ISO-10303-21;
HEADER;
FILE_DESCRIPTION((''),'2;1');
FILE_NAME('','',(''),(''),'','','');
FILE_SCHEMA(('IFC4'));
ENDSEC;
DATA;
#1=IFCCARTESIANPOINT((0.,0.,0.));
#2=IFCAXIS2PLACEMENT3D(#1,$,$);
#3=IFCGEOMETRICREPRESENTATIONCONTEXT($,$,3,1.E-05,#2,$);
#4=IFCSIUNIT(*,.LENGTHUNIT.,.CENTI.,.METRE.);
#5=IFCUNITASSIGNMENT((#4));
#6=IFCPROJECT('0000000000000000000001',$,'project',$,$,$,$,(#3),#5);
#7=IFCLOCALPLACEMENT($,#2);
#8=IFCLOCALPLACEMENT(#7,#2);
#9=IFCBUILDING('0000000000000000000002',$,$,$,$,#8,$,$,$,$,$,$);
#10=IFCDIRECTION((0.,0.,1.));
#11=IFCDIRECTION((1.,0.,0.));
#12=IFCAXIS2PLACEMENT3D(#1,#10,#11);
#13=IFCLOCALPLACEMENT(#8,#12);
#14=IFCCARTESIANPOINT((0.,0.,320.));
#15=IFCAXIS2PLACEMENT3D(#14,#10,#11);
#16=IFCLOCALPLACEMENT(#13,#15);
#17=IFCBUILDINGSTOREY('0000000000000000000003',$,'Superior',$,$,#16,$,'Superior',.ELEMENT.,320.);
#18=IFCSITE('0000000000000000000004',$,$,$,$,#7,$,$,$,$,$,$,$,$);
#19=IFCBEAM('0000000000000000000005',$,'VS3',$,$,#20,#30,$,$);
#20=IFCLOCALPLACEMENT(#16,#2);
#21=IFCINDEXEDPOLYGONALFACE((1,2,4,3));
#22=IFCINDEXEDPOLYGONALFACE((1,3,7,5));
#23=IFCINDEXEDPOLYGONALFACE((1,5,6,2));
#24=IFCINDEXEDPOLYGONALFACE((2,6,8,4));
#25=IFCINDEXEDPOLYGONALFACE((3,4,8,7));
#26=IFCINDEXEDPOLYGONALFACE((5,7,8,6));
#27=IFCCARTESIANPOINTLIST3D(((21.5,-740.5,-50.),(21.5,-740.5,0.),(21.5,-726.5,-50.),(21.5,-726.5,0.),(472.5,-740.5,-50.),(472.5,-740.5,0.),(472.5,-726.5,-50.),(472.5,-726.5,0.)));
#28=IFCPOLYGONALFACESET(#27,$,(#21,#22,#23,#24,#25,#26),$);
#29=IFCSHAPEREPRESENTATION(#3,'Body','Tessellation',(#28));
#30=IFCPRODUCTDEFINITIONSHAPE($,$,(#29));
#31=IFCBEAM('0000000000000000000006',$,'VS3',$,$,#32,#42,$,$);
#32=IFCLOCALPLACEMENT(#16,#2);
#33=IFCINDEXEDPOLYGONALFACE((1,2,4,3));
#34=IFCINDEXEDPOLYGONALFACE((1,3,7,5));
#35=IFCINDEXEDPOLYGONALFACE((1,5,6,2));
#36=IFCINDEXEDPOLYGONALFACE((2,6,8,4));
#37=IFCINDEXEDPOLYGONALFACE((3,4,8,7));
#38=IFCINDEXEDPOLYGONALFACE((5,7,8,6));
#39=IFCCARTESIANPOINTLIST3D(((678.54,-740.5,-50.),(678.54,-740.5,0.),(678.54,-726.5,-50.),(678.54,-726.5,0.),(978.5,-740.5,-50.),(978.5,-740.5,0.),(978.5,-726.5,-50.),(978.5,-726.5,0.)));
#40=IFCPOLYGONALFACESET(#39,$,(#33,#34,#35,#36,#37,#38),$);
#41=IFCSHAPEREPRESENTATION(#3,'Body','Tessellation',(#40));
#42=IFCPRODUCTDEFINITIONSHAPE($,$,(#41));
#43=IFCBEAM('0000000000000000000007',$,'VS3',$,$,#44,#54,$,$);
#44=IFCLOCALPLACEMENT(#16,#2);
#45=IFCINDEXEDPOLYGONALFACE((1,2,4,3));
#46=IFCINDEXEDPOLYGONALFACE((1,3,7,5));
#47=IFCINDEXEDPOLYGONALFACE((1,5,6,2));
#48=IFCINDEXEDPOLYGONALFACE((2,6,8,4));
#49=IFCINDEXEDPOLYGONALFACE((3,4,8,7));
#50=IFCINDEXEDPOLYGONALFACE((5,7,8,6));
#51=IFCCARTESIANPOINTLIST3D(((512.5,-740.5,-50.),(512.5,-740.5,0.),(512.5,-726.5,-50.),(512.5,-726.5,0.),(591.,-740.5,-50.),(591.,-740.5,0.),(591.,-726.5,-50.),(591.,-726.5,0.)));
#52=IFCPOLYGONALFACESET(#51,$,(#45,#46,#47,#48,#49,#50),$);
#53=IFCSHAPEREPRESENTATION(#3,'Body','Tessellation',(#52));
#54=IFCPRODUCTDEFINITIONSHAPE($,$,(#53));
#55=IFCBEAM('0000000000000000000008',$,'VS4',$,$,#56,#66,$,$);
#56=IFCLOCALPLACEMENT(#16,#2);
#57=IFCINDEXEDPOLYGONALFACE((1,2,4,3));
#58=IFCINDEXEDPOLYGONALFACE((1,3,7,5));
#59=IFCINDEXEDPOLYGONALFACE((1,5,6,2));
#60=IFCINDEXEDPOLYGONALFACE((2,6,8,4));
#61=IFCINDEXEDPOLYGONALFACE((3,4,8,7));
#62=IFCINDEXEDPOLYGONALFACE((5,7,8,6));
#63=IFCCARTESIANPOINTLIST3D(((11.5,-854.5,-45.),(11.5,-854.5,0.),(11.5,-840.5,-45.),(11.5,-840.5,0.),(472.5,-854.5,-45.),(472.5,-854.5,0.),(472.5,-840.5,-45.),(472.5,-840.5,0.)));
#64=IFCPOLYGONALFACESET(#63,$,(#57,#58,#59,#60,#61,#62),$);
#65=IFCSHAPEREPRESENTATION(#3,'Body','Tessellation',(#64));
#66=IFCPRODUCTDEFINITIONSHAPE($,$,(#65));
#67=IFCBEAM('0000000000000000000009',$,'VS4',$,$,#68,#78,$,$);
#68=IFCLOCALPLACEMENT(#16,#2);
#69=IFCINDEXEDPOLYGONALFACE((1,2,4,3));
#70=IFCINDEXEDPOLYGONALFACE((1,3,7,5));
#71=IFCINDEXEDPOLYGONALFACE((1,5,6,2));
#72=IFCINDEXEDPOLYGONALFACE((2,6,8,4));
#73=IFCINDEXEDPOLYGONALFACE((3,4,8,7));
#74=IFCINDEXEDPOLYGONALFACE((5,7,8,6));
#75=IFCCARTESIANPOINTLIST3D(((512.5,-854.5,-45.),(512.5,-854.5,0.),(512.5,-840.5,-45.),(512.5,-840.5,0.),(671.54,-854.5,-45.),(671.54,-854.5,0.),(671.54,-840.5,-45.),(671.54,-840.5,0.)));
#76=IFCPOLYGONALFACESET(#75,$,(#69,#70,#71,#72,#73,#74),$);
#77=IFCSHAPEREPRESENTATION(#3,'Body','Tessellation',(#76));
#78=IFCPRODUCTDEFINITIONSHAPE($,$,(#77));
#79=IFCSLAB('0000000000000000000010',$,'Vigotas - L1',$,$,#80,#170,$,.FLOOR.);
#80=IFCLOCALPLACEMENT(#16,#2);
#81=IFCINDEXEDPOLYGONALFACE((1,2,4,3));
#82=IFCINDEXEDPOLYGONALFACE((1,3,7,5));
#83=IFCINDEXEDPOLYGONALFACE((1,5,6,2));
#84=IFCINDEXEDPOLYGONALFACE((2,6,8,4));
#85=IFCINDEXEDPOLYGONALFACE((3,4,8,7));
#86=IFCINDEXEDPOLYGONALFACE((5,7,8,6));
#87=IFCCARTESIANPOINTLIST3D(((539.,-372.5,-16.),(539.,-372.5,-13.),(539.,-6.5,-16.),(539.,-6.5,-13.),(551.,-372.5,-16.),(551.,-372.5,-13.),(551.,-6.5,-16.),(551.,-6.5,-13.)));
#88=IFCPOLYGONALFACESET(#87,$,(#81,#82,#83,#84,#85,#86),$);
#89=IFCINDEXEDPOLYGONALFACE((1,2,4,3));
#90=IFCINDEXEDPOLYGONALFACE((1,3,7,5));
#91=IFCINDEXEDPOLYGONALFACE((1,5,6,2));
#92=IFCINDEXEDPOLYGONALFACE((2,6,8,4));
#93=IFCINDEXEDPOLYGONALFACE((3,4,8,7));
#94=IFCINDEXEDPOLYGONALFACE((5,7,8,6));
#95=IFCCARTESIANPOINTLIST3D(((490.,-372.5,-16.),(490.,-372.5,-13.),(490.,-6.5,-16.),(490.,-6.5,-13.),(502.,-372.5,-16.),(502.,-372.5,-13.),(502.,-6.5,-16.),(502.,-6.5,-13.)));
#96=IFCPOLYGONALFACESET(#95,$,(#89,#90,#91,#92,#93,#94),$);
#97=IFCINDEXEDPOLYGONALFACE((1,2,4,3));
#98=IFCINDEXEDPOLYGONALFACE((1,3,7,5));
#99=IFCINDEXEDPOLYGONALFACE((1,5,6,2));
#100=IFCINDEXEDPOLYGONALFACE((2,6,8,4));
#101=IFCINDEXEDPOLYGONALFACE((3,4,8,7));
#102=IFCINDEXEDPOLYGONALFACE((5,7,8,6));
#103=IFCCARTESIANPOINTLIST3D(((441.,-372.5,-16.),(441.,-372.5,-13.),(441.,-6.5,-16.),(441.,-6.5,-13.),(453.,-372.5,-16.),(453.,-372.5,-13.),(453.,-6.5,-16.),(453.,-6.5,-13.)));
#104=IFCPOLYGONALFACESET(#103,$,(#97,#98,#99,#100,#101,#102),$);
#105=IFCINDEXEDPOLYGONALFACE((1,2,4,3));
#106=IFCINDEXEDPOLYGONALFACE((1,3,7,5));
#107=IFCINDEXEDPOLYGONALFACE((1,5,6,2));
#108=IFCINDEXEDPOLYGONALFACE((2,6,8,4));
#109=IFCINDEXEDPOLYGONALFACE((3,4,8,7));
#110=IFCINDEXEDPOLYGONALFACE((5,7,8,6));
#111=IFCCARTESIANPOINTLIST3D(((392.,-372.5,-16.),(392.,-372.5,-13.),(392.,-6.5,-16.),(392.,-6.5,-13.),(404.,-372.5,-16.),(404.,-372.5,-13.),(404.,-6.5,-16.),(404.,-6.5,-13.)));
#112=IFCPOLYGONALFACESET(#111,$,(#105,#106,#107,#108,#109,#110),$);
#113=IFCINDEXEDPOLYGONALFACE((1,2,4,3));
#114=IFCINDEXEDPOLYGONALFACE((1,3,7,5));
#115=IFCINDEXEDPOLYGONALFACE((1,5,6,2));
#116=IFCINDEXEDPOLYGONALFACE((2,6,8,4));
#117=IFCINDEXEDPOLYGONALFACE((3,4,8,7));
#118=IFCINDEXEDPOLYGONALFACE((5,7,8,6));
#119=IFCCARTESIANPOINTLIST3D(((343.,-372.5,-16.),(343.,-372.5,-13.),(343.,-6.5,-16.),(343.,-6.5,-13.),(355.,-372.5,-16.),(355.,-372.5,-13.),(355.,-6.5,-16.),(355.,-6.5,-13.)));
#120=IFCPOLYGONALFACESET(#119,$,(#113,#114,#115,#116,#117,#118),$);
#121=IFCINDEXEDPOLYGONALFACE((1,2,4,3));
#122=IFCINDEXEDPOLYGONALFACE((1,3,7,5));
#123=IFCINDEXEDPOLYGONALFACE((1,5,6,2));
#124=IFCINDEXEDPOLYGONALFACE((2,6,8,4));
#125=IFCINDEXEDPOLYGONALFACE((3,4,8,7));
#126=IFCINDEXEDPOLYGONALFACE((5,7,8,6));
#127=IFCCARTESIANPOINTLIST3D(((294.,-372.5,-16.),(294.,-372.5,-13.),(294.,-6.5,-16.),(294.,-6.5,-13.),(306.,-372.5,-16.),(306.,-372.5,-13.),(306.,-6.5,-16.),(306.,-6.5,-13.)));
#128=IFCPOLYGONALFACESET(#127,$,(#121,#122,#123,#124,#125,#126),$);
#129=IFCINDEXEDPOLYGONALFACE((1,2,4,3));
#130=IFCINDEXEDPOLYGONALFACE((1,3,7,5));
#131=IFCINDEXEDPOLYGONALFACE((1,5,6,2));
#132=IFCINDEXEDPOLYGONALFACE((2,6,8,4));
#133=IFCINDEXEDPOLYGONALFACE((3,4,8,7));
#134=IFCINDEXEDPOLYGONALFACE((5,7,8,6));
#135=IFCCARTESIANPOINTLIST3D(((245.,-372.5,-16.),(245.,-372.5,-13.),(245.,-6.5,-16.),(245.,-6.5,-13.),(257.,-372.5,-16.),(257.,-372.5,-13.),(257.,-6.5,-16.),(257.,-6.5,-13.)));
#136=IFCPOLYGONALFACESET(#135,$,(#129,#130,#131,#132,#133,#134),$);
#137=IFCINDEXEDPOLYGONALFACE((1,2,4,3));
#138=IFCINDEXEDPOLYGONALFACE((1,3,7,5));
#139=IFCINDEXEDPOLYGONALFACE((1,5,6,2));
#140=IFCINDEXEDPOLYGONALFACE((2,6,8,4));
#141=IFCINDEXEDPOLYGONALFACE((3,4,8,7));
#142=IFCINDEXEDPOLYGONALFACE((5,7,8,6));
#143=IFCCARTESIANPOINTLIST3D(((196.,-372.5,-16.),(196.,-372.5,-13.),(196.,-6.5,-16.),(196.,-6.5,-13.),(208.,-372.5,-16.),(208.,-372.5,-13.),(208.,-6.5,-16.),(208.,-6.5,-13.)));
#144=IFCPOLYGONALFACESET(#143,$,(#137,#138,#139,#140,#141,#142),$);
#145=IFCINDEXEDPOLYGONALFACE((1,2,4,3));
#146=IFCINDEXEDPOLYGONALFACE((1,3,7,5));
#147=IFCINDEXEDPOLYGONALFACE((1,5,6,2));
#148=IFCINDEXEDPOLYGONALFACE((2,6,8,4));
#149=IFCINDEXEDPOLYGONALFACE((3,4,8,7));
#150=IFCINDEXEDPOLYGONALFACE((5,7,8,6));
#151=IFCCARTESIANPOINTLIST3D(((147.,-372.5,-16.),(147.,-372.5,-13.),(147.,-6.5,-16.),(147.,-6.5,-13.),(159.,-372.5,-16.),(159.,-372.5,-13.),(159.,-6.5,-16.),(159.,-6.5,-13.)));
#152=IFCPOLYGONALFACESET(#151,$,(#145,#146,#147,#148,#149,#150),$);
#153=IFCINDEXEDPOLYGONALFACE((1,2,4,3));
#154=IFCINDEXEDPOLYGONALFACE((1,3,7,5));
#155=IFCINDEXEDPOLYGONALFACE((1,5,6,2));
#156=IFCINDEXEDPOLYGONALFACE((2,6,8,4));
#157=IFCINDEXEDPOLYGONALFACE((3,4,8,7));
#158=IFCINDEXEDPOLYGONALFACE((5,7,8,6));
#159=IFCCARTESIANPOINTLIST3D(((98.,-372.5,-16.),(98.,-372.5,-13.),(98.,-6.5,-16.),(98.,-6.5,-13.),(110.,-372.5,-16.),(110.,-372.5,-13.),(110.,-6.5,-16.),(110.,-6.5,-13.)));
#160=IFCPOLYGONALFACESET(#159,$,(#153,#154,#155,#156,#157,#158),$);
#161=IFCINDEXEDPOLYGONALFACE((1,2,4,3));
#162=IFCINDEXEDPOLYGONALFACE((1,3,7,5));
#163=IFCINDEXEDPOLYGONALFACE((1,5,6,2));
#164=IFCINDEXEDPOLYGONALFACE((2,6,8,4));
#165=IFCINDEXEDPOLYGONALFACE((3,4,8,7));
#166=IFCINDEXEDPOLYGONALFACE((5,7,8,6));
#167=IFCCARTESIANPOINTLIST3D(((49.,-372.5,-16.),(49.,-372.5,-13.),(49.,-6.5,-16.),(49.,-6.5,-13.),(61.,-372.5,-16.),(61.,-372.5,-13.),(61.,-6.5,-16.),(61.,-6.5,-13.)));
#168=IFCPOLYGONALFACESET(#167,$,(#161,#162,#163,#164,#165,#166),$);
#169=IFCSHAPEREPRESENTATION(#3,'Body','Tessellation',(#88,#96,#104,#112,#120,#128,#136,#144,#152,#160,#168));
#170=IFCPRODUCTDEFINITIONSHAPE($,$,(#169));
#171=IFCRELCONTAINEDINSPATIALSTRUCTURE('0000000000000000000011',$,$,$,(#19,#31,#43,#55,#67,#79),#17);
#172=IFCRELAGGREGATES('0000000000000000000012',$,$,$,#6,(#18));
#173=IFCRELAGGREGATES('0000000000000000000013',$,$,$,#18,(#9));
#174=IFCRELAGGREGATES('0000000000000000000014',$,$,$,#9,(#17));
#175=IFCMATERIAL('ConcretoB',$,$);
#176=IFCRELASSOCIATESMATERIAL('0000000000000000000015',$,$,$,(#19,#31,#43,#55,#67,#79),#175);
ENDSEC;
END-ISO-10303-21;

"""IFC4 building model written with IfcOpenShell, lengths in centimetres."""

from ifc_helpers import new_model, si_unit, frame, origin, origin_with_axes, place, context, project, spatial, polyline, outline, extrude, material, element, save


model = new_model("IFC4")

# Units and contexts
context_of_model = context(None, 3, precision=1e-05, world=origin())
ifc_project = project(units=[si_unit("LENGTHUNIT", "METRE", prefix="CENTI")], contexts=[context_of_model])

# Site, building, storey
site_placement = place(None, origin())
site = spatial("IfcSite", under=ifc_project, at=site_placement)
building_placement = place(site_placement, origin())
building = spatial("IfcBuilding", under=site, at=building_placement)
placement = place(building_placement, origin_with_axes())
storey_placement = place(placement, frame((0.0, 0.0, 320.0), z_axis=(0.0, 0.0, 1.0), x_axis=(1.0, 0.0, 0.0)))
storey = spatial("IfcBuildingStorey", under=building, at=storey_placement, Name="Superior", LongName="Superior", CompositionType="ELEMENT", Elevation=320.0)

# Shared definitions
ifc_material = material(Name="ConcretoB")

# Beams
beam_1_placement = place(storey_placement, frame((247.0, -733.5, 0.0), z_axis=(0.0, 0.0, 1.0), x_axis=(1.0, 0.0, 0.0)))
element("IfcBeam", 1, at=beam_1_placement, inside=storey, material=ifc_material, Name="VS3", context=context_of_model, shape_type="SolidModel", body=[
    extrude(outline(polyline([(-7.0, -25.0), (7.0, -25.0), (7.0, 25.0), (-7.0, 25.0), (-7.0, -25.0)])), frame((-225.5, 0.0, -25.0), z_axis=(1.0, 0.0, 0.0), x_axis=(0.0, -1.0, 0.0)), (0.0, 0.0, 1.0), 451.0),
])
beam_2_placement = place(storey_placement, frame((828.52, -733.5, 0.0), z_axis=(0.0, 0.0, 1.0), x_axis=(1.0, 0.0, 0.0)))
element("IfcBeam", 2, at=beam_2_placement, inside=storey, material=ifc_material, Name="VS3", context=context_of_model, shape_type="SolidModel", body=[
    extrude(outline(polyline([(-7.0, -25.0), (7.0, -25.0), (7.0, 25.0), (-7.0, 25.0), (-7.0, -25.0)])), frame((-149.98, 0.0, -25.0), z_axis=(1.0, 0.0, 0.0), x_axis=(0.0, -1.0, 0.0)), (0.0, 0.0, 1.0), 299.96),
])
beam_3_placement = place(storey_placement, frame((551.75, -733.5, 0.0), z_axis=(0.0, 0.0, 1.0), x_axis=(1.0, 0.0, 0.0)))
element("IfcBeam", 3, at=beam_3_placement, inside=storey, material=ifc_material, Name="VS3", context=context_of_model, shape_type="SolidModel", body=[
    extrude(outline(polyline([(-7.0, -25.0), (7.0, -25.0), (7.0, 25.0), (-7.0, 25.0), (-7.0, -25.0)])), frame((-39.25, 0.0, -25.0), z_axis=(1.0, 0.0, 0.0), x_axis=(0.0, -1.0, 0.0)), (0.0, 0.0, 1.0), 78.5),
])
beam_4_placement = place(storey_placement, frame((242.0, -847.5, 0.0), z_axis=(0.0, 0.0, 1.0), x_axis=(1.0, 0.0, 0.0)))
element("IfcBeam", 4, at=beam_4_placement, inside=storey, material=ifc_material, Name="VS4", context=context_of_model, shape_type="SolidModel", body=[
    extrude(outline(polyline([(-7.0, -22.5), (7.0, -22.5), (7.0, 22.5), (-7.0, 22.5), (-7.0, -22.5)])), frame((-230.5, 0.0, -22.5), z_axis=(1.0, 0.0, 0.0), x_axis=(0.0, -1.0, 0.0)), (0.0, 0.0, 1.0), 461.0),
])
beam_5_placement = place(storey_placement, frame((592.02, -847.5, 0.0), z_axis=(0.0, 0.0, 1.0), x_axis=(1.0, 0.0, 0.0)))
element("IfcBeam", 5, at=beam_5_placement, inside=storey, material=ifc_material, Name="VS4", context=context_of_model, shape_type="SolidModel", body=[
    extrude(outline(polyline([(-7.0, -22.5), (7.0, -22.5), (7.0, 22.5), (-7.0, 22.5), (-7.0, -22.5)])), frame((-79.52, 0.0, -22.5), z_axis=(1.0, 0.0, 0.0), x_axis=(0.0, -1.0, 0.0)), (0.0, 0.0, 1.0), 159.04),
])

# Slab
slab_1_placement = place(storey_placement, frame((300.0, -189.5, -13.0), z_axis=(0.0, 0.0, 1.0), x_axis=(1.0, 0.0, 0.0)))
element("IfcSlab", 6, at=slab_1_placement, inside=storey, material=ifc_material, Name="Vigotas - L1", PredefinedType="FLOOR", context=context_of_model, shape_type="SolidModel", body=[
    extrude(outline(polyline([(6.0, 1.5), (-6.0, 1.5), (-6.0, -1.5), (6.0, -1.5), (6.0, 1.5), (6.0, 1.5)])), frame((245.0, -183.0, -1.5), z_axis=(0.0, 1.0, 0.0), x_axis=(1.0, 0.0, 0.0)), (0.0, 0.0, 1.0), 366.0),
    extrude(outline(polyline([(6.0, 1.5), (-6.0, 1.5), (-6.0, -1.5), (6.0, -1.5), (6.0, 1.5), (6.0, 1.5)])), frame((196.0, -183.0, -1.5), z_axis=(0.0, 1.0, 0.0), x_axis=(1.0, 0.0, 0.0)), (0.0, 0.0, 1.0), 366.0),
    extrude(outline(polyline([(6.0, 1.5), (-6.0, 1.5), (-6.0, -1.5), (6.0, -1.5), (6.0, 1.5), (6.0, 1.5)])), frame((147.0, -183.0, -1.5), z_axis=(0.0, 1.0, 0.0), x_axis=(1.0, 0.0, 0.0)), (0.0, 0.0, 1.0), 366.0),
    extrude(outline(polyline([(6.0, 1.5), (-6.0, 1.5), (-6.0, -1.5), (6.0, -1.5), (6.0, 1.5), (6.0, 1.5)])), frame((98.0, -183.0, -1.5), z_axis=(0.0, 1.0, 0.0), x_axis=(1.0, 0.0, 0.0)), (0.0, 0.0, 1.0), 366.0),
    extrude(outline(polyline([(6.0, 1.5), (-6.0, 1.5), (-6.0, -1.5), (6.0, -1.5), (6.0, 1.5), (6.0, 1.5)])), frame((49.0, -183.0, -1.5), z_axis=(0.0, 1.0, 0.0), x_axis=(1.0, 0.0, 0.0)), (0.0, 0.0, 1.0), 366.0),
    extrude(outline(polyline([(6.0, 1.5), (-6.0, 1.5), (-6.0, -1.5), (6.0, -1.5), (6.0, 1.5), (6.0, 1.5)])), frame((0.0, -183.0, -1.5), z_axis=(0.0, 1.0, 0.0), x_axis=(1.0, 0.0, 0.0)), (0.0, 0.0, 1.0), 366.0),
    extrude(outline(polyline([(6.0, 1.5), (-6.0, 1.5), (-6.0, -1.5), (6.0, -1.5), (6.0, 1.5), (6.0, 1.5)])), frame((-49.0, -183.0, -1.5), z_axis=(0.0, 1.0, 0.0), x_axis=(1.0, 0.0, 0.0)), (0.0, 0.0, 1.0), 366.0),
    extrude(outline(polyline([(6.0, 1.5), (-6.0, 1.5), (-6.0, -1.5), (6.0, -1.5), (6.0, 1.5), (6.0, 1.5)])), frame((-98.0, -183.0, -1.5), z_axis=(0.0, 1.0, 0.0), x_axis=(1.0, 0.0, 0.0)), (0.0, 0.0, 1.0), 366.0),
    extrude(outline(polyline([(6.0, 1.5), (-6.0, 1.5), (-6.0, -1.5), (6.0, -1.5), (6.0, 1.5), (6.0, 1.5)])), frame((-147.0, -183.0, -1.5), z_axis=(0.0, 1.0, 0.0), x_axis=(1.0, 0.0, 0.0)), (0.0, 0.0, 1.0), 366.0),
    extrude(outline(polyline([(6.0, 1.5), (-6.0, 1.5), (-6.0, -1.5), (6.0, -1.5), (6.0, 1.5), (6.0, 1.5)])), frame((-196.0, -183.0, -1.5), z_axis=(0.0, 1.0, 0.0), x_axis=(1.0, 0.0, 0.0)), (0.0, 0.0, 1.0), 366.0),
    extrude(outline(polyline([(6.0, 1.5), (-6.0, 1.5), (-6.0, -1.5), (6.0, -1.5), (6.0, 1.5), (6.0, 1.5)])), frame((-245.0, -183.0, -1.5), z_axis=(0.0, 1.0, 0.0), x_axis=(1.0, 0.0, 0.0)), (0.0, 0.0, 1.0), 366.0),
])

save(model, "model.ifc")
